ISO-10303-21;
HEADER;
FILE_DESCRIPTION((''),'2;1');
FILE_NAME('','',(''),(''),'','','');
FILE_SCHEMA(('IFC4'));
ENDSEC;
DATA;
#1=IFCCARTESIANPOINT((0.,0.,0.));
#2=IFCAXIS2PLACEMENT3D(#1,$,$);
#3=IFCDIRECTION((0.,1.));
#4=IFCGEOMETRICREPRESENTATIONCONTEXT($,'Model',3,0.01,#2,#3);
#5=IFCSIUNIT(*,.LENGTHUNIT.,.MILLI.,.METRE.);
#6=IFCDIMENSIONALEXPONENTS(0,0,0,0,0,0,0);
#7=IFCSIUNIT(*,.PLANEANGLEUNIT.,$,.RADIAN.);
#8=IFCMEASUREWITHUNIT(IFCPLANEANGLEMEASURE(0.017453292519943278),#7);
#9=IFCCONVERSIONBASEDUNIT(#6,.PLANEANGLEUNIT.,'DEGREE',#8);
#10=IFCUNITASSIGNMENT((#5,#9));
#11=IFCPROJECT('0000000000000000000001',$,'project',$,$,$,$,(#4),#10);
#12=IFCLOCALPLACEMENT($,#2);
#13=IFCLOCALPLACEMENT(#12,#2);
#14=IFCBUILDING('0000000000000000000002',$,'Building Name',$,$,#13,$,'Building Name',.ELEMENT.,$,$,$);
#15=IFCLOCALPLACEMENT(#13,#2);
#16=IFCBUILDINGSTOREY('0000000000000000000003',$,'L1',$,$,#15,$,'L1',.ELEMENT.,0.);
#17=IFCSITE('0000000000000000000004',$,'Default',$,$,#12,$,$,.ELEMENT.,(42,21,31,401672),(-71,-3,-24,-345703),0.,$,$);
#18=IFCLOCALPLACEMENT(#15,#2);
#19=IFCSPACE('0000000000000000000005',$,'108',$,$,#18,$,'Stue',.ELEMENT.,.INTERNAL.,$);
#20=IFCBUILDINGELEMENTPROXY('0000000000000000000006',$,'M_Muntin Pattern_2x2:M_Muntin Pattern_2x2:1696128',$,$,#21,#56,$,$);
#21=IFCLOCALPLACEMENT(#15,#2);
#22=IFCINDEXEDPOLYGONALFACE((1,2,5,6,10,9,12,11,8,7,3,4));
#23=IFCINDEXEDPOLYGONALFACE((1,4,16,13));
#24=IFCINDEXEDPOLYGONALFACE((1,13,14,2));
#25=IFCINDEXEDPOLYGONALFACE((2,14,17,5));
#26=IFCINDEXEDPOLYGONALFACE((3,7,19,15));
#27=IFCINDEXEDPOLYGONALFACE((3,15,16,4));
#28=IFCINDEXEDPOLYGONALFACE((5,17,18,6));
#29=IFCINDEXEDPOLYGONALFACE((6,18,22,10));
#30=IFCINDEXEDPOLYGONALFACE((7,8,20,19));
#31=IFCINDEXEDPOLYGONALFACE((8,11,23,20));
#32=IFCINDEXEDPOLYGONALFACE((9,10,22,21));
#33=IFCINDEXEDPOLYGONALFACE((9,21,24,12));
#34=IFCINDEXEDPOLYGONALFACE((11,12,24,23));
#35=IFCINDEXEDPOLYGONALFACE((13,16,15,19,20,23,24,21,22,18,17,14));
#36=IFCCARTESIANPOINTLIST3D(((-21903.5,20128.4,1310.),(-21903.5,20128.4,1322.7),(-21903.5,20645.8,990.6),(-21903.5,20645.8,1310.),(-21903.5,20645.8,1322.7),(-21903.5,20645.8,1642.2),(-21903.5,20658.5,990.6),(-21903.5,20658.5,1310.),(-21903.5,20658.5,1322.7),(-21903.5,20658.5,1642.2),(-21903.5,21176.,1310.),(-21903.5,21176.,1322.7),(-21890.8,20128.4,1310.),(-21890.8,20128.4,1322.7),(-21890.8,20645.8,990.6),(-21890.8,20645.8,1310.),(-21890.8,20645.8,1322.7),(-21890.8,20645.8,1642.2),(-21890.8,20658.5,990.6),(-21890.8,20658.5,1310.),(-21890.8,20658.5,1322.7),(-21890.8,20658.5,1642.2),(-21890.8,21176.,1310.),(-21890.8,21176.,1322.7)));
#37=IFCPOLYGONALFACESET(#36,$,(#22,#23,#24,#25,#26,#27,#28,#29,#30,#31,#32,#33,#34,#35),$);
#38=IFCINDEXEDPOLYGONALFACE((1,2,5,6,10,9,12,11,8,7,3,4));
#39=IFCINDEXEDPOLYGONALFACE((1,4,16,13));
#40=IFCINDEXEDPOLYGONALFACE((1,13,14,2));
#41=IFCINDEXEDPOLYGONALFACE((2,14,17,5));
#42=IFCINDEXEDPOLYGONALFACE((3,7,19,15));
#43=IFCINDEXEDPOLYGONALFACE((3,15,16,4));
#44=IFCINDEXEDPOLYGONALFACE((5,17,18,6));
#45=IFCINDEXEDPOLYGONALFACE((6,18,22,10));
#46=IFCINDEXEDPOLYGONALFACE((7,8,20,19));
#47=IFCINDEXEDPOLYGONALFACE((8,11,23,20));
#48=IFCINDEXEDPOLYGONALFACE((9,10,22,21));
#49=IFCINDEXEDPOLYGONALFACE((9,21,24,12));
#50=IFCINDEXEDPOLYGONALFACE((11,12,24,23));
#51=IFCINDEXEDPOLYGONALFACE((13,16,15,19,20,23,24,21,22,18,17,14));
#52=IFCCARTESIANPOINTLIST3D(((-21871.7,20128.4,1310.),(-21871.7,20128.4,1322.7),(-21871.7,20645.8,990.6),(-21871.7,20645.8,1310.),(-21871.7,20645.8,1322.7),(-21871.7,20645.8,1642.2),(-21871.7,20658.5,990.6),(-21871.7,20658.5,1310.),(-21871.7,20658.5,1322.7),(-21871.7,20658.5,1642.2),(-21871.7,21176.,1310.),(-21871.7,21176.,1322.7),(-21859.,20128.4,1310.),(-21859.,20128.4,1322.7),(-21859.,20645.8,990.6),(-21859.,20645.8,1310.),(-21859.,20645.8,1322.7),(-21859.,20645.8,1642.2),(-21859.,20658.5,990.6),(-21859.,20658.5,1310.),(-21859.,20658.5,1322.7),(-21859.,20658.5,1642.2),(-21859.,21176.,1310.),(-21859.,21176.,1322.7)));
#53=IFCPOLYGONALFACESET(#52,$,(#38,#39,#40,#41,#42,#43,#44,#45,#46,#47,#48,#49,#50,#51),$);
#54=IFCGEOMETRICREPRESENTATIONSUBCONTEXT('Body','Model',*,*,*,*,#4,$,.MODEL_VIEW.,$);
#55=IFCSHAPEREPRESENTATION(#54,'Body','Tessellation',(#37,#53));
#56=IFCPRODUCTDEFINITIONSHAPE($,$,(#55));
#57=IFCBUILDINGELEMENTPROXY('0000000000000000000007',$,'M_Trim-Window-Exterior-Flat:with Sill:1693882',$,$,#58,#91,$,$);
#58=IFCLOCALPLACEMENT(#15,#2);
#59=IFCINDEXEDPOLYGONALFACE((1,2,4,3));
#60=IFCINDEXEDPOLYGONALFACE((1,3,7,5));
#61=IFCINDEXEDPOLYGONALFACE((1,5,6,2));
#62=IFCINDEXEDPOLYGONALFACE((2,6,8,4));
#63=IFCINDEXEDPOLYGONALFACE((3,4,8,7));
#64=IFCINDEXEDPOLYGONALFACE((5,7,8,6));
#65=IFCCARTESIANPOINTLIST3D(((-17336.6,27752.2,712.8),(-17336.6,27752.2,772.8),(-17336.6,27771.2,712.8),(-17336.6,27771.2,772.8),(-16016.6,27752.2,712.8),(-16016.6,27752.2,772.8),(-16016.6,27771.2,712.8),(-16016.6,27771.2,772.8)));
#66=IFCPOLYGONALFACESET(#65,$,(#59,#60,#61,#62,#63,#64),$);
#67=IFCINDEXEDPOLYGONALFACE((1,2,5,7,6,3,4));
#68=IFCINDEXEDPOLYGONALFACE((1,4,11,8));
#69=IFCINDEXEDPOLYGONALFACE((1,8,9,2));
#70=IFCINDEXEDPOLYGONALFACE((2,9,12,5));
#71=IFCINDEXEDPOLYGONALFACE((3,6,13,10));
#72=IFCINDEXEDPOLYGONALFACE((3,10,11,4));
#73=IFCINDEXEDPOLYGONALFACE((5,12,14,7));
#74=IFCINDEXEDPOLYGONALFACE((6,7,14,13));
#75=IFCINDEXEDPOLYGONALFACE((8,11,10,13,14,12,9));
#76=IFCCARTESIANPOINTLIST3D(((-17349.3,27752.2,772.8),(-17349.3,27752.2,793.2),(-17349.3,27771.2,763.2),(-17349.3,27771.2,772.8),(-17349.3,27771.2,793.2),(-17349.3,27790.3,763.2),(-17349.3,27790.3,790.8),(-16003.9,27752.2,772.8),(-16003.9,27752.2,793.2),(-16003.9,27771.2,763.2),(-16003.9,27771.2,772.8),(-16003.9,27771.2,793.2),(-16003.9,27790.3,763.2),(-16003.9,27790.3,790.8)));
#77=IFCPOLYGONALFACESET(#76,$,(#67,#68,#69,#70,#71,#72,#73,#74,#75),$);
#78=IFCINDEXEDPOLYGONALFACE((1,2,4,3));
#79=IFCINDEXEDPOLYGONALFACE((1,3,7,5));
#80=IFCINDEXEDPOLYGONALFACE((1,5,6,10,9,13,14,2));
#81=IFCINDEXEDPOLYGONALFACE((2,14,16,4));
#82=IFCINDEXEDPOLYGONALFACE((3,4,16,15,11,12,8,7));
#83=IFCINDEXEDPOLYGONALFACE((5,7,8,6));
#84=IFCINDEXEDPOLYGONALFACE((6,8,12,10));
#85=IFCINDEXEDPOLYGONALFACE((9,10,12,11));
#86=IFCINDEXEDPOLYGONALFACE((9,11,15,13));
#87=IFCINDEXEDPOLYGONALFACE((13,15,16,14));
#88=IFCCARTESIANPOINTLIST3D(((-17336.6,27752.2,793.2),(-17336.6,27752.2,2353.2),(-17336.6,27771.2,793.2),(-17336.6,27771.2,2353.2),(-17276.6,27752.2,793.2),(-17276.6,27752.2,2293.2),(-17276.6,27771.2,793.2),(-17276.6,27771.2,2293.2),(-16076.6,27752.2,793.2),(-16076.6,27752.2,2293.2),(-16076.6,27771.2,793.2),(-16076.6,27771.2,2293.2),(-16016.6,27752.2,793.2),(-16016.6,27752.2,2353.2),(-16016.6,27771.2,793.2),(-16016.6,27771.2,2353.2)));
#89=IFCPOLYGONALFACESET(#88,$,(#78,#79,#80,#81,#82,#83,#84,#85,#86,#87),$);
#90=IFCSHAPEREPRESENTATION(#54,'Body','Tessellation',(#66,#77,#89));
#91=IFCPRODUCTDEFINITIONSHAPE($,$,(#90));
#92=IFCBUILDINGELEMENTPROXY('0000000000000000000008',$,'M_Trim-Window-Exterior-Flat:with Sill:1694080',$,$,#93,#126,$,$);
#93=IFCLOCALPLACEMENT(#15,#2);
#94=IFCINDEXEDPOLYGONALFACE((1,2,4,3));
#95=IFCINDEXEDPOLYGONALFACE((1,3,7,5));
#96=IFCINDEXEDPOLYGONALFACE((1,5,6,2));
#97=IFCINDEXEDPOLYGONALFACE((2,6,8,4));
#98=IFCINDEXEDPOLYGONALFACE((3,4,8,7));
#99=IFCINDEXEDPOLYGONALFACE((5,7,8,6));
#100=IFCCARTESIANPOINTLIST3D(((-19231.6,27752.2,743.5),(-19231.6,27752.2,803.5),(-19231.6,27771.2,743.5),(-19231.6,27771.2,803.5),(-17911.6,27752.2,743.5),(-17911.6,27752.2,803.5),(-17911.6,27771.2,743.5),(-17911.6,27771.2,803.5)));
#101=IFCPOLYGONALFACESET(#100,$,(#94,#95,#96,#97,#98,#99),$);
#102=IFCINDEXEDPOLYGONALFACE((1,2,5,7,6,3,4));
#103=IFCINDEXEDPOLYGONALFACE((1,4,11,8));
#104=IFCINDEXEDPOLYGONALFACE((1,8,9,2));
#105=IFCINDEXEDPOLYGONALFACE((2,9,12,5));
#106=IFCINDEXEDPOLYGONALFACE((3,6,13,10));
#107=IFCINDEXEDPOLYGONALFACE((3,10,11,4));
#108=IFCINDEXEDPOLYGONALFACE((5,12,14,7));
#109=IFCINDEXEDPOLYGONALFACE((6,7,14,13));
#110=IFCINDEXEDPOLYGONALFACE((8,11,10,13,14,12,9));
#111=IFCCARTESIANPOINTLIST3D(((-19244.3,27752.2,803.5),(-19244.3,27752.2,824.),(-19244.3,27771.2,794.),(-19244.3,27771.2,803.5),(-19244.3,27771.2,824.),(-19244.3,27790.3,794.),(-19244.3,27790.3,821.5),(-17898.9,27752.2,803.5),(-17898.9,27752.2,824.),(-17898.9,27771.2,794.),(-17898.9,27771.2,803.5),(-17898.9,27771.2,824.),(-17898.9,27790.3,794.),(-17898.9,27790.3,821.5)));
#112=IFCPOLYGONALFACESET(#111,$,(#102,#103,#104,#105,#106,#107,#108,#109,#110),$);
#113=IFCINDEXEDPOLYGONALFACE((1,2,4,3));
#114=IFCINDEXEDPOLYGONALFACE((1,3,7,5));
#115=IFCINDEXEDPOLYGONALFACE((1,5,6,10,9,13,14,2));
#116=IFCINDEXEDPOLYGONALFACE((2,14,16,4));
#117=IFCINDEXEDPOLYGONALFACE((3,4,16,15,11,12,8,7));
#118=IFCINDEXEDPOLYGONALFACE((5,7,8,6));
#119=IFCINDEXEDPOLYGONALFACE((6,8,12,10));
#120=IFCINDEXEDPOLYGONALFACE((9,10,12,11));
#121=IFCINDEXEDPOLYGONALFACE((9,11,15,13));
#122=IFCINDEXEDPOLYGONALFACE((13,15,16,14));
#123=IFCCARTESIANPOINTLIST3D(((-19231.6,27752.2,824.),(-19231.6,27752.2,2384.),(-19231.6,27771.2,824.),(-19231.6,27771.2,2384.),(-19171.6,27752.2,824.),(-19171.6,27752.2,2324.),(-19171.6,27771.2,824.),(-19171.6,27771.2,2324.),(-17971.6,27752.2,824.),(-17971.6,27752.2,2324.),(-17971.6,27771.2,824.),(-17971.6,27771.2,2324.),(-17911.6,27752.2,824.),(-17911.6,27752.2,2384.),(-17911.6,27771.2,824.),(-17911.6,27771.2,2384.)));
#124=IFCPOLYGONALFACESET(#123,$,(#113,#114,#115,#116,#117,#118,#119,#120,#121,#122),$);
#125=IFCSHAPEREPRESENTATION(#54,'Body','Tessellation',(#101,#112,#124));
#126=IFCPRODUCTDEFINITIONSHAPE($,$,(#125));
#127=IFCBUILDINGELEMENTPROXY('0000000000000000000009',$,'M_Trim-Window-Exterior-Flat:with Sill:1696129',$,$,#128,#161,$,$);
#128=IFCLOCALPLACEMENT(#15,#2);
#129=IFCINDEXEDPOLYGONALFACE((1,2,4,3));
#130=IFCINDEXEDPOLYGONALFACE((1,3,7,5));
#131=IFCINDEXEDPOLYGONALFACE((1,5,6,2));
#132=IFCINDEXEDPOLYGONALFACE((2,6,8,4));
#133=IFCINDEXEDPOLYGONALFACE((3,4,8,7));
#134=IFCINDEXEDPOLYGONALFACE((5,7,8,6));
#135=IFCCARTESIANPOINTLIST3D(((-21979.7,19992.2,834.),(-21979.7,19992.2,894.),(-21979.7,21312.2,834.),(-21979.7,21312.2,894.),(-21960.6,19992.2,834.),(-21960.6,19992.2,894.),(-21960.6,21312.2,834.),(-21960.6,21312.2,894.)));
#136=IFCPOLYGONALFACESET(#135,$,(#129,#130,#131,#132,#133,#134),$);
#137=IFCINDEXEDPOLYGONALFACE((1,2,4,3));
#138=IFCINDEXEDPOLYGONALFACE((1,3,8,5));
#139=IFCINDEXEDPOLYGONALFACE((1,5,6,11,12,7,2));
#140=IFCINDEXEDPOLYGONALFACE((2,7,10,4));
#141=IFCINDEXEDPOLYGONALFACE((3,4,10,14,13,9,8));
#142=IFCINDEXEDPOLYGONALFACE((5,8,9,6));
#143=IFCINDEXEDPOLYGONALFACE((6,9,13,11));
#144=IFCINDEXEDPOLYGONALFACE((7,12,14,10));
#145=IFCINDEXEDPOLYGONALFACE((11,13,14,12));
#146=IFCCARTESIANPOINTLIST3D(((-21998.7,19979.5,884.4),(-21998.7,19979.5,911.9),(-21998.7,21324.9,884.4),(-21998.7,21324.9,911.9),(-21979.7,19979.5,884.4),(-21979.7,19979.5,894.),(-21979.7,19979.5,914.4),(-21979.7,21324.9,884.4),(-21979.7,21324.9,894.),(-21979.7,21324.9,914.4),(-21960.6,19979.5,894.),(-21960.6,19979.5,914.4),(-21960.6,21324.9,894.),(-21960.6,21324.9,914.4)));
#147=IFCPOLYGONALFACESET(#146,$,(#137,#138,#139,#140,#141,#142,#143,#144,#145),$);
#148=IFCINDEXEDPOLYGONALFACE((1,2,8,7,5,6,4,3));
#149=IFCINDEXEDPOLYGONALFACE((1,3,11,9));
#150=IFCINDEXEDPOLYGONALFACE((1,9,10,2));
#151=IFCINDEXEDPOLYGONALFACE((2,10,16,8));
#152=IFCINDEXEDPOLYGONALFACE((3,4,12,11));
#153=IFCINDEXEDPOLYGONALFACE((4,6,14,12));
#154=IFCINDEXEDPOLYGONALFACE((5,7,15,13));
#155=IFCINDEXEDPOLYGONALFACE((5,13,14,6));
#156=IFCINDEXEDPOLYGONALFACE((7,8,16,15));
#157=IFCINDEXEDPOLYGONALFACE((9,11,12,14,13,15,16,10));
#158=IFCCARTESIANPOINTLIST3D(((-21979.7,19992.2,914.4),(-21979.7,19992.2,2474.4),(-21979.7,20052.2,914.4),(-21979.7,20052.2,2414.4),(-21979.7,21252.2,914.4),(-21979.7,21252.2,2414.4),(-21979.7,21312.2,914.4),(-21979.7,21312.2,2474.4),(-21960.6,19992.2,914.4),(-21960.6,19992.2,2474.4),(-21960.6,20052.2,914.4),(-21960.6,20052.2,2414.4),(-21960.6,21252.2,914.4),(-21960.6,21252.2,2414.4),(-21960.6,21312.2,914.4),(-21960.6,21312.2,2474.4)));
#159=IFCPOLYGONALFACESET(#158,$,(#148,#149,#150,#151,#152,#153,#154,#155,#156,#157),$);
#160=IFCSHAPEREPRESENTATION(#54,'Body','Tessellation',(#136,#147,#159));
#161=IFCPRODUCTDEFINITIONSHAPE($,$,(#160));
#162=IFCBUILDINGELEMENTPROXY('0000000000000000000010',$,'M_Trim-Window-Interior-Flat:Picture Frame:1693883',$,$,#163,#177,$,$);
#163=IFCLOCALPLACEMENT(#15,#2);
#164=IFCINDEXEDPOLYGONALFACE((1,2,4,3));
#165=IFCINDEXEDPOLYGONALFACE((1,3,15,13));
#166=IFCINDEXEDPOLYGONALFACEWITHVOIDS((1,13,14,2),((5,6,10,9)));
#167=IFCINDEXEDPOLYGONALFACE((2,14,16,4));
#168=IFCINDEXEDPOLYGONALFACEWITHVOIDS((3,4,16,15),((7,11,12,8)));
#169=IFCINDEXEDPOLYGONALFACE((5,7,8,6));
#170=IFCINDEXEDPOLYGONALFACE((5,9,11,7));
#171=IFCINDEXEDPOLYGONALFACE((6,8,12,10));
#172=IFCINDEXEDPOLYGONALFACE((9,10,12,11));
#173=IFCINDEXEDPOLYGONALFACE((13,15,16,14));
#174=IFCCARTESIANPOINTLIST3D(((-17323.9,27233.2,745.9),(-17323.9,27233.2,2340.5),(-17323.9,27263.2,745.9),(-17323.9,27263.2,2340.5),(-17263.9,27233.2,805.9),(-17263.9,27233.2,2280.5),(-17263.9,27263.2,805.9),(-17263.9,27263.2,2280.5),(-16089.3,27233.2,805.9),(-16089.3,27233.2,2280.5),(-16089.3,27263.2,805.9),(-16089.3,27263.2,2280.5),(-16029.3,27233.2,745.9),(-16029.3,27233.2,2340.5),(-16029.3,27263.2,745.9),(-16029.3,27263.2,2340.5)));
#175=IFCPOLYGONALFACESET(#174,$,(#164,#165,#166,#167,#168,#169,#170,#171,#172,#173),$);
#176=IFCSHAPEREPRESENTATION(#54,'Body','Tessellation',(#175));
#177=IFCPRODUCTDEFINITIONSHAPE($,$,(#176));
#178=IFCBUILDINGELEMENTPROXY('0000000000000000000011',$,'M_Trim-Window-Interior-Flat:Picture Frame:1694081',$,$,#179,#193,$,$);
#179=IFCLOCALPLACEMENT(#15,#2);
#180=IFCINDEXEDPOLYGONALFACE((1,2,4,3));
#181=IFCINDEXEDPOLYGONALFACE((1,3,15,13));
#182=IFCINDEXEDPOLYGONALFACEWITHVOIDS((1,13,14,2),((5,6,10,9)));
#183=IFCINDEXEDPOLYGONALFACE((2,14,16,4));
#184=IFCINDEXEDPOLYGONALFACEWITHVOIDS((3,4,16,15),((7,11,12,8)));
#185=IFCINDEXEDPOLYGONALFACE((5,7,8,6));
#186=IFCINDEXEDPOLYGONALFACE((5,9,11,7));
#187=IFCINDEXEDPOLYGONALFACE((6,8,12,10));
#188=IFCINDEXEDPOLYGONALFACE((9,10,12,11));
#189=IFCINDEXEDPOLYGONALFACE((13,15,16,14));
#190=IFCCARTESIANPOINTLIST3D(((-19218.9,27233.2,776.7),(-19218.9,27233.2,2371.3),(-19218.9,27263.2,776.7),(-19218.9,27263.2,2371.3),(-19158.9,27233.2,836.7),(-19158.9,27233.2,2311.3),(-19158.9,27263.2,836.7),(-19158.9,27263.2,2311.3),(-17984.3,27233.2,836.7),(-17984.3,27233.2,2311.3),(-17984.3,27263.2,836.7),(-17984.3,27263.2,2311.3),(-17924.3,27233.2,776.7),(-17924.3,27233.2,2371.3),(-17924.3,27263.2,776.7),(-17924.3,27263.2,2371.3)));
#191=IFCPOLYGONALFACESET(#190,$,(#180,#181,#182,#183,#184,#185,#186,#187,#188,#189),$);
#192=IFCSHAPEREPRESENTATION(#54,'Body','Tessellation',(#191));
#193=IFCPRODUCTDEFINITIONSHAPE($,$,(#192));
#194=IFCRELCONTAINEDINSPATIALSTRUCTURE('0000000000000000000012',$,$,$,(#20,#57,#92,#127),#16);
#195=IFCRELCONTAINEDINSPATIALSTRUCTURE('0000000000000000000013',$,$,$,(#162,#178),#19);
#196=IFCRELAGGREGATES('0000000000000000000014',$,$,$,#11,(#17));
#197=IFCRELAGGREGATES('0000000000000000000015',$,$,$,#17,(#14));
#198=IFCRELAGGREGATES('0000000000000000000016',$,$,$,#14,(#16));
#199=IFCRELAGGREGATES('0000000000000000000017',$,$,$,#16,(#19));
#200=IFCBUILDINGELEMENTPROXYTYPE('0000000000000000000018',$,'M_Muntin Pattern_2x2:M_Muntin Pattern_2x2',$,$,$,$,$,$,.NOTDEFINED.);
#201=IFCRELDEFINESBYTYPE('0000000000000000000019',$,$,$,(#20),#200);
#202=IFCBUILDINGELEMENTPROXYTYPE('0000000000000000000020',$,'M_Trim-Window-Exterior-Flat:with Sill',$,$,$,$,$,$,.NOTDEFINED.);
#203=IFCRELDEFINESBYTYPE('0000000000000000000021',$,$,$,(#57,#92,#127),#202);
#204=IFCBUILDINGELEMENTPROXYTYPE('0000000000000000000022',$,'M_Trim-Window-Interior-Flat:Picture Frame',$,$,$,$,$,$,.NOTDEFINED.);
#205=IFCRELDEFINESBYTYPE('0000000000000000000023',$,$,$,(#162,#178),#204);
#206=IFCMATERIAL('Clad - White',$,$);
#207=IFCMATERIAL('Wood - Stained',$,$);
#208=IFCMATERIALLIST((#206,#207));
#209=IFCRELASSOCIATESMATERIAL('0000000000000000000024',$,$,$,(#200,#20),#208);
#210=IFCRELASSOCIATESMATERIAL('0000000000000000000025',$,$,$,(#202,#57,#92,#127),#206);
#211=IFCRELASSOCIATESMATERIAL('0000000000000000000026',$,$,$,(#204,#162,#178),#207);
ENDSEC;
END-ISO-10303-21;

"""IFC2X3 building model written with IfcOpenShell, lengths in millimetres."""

from ifc_helpers import new_model, entity, si_unit, converted_unit, direction, frame, frame_2d, origin, place, context, subcontext, project, spatial, polyline, rectangle, outline, extrude, source, transform, mapped, material, material_list, type_object, type_shapes, element, save


model = new_model("IFC2X3")

# Units and contexts
model_context = context("Model", 3, precision=0.01, world=origin(), true_north=direction((0.0, 1.0)))
body_context = subcontext(model_context, "Body", "Model", "MODEL_VIEW")
ifc_project = project(units=[si_unit("LENGTHUNIT", "METRE", prefix="MILLI"), converted_unit("PLANEANGLEUNIT", "DEGREE", entity("IfcPlaneAngleMeasure", 0.017453292519943278), si_unit("PLANEANGLEUNIT", "RADIAN"), dimensions=[0, 0, 0, 0, 0, 0, 0])], contexts=[model_context])

# Site, building, storey
site_placement = place(None, origin())
site = spatial("IfcSite", under=ifc_project, at=site_placement, Name="Default", CompositionType="ELEMENT", RefLatitude=(42, 21, 31, 401672), RefLongitude=(-71, -3, -24, -345703), RefElevation=0.0)
building_placement = place(site_placement, origin())
building = spatial("IfcBuilding", under=site, at=building_placement, Name="Building Name", LongName="Building Name", CompositionType="ELEMENT")
storey_placement = place(building_placement, origin())
storey = spatial("IfcBuildingStorey", under=building, at=storey_placement, Name="L1", LongName="L1", CompositionType="ELEMENT", Elevation=0.0)

# Shared definitions
ifc_material_1 = material(Name="Wood - Stained")

# Building element proxies
ifc_material_2 = material(Name="Clad - White")
ifc_material_list_1 = material_list([ifc_material_2, ifc_material_1])
building_element_proxy_type_1 = type_object("IfcBuildingElementProxyType", Name="M_Muntin Pattern_2x2:M_Muntin Pattern_2x2", PredefinedType="NOTDEFINED", material=ifc_material_list_1)
shared_shape_1 = source(origin(), body_context, "Body", "SweptSolid", [
    extrude(outline(polyline([(6.4, -6.4), (325.8, -6.4), (325.8, 6.3), (6.4, 6.3), (6.4, 523.8), (-6.3, 523.8), (-6.3, 6.3), (-325.8, 6.3), (-325.8, -6.4), (-6.3, -6.4), (-6.3, -523.8), (6.4, -523.8), (6.4, -6.4)])), frame((0.0, 9.5, 325.8), z_axis=(0.0, 1.0, 0.0), x_axis=(0.0, 0.0, 1.0)), (0.0, 0.0, 1.0), 12.7),
    extrude(outline(polyline([(6.4, -6.4), (325.8, -6.4), (325.8, 6.3), (6.4, 6.3), (6.4, 523.8), (-6.3, 523.8), (-6.3, 6.3), (-325.8, 6.3), (-325.8, -6.4), (-6.3, -6.4), (-6.3, -523.8), (6.4, -523.8), (6.4, -6.4)])), frame((0.0, -22.2, 325.8), z_axis=(0.0, 1.0, 0.0), x_axis=(0.0, 0.0, 1.0)), (0.0, 0.0, 1.0), 12.7),
])
type_shapes(building_element_proxy_type_1, [shared_shape_1])
proxy_1_placement = place(storey_placement, frame((-21881.3, 20652.2, 990.6), z_axis=(0.0, 0.0, 1.0), x_axis=(0.0, 1.0, 0.0)))
element("IfcBuildingElementProxy", 1, at=proxy_1_placement, inside=storey, type_object=building_element_proxy_type_1, material=ifc_material_list_1, Name="M_Muntin Pattern_2x2:M_Muntin Pattern_2x2:1696128", context=body_context, shape_type="MappedRepresentation", body=[
    mapped(shared_shape_1, transform((0.0, 0.0, 0.0), scale=1.0)),
])
building_element_proxy_type_2 = type_object("IfcBuildingElementProxyType", Name="M_Trim-Window-Exterior-Flat:with Sill", PredefinedType="NOTDEFINED", material=ifc_material_2)
shared_shape_2 = source(origin(), body_context, "Body", "SweptSolid", [
    extrude(rectangle(XDim=1320.0, YDim=60.0, at=frame_2d((0.0, 0.0), x_axis=(1.0, 0.0))), frame((0.0, -1550.4, 0.0), z_axis=(0.0, 0.0, 1.0), x_axis=(-1.0, 0.0, 0.0)), (0.0, 0.0, 1.0), 19.0),
    extrude(outline(polyline([(-19.0, -15.2), (0.0, -15.2), (0.0, -5.7), (19.0, -5.7), (19.0, 14.8), (0.0, 14.8), (-19.0, 12.3), (-19.0, -15.2)])), frame((-672.7, -1514.8, 19.0), z_axis=(1.0, 0.0, 0.0), x_axis=(0.0, 0.0, -1.0)), (0.0, 0.0, 1.0), 1345.4),
    extrude(outline(polyline([(-795.0, -660.0), (765.0, -660.0), (765.0, -600.0), (-735.0, -600.0), (-735.0, 600.0), (765.0, 600.0), (765.0, 660.0), (-795.0, 660.0), (-795.0, -660.0)])), frame((0.0, -735.0, 0.0), z_axis=(0.0, 0.0, 1.0), x_axis=(0.0, -1.0, 0.0)), (0.0, 0.0, 1.0), 19.0),
])
type_shapes(building_element_proxy_type_2, [shared_shape_2])
for number, where, z_axis, x_axis, name in (
    (2, (-16676.6, 27752.2, 2293.2), (0.0, 1.0, 0.0), (-1.0, 0.0, 0.0), "M_Trim-Window-Exterior-Flat:with Sill:1693882"),
    (3, (-18571.6, 27752.2, 2324.0), (0.0, 1.0, 0.0), (-1.0, 0.0, 0.0), "M_Trim-Window-Exterior-Flat:with Sill:1694080"),
    (4, (-21960.6, 20652.2, 2414.4), (-1.0, 0.0, 0.0), (0.0, -1.0, 0.0), "M_Trim-Window-Exterior-Flat:with Sill:1696129"),
):
    element("IfcBuildingElementProxy", number, at=place(storey_placement, frame(where, z_axis=z_axis, x_axis=x_axis)), inside=storey, type_object=building_element_proxy_type_2, material=ifc_material_2, Name=name, context=body_context, shape_type="MappedRepresentation", body=[
        mapped(shared_shape_2, transform((0.0, 0.0, 0.0), scale=1.0)),
    ])

# Shared definitions
space_1_placement = place(storey_placement, origin())
space_1 = spatial("IfcSpace", under=storey, at=space_1_placement, Name="108", LongName="Stue", CompositionType="ELEMENT", InteriorOrExteriorSpace="INTERNAL")

# Building element proxies
building_element_proxy_type_3 = type_object("IfcBuildingElementProxyType", Name="M_Trim-Window-Interior-Flat:Picture Frame", PredefinedType="NOTDEFINED", material=ifc_material_1)
shared_shape_3 = source(origin(), body_context, "Body", "SweptSolid", [
    extrude(outline(polyline([(-647.3, -797.3), (647.3, -797.3), (647.3, 797.3), (-647.3, 797.3), (-647.3, -797.3)]), holes=[polyline([(-587.3, -737.3), (-587.3, 737.3), (587.3, 737.3), (587.3, -737.3), (-587.3, -737.3)])]), frame((0.0, -750.0, 0.0), z_axis=(0.0, 0.0, 1.0), x_axis=(-1.0, 0.0, 0.0)), (0.0, 0.0, 1.0), 30.0),
])
type_shapes(building_element_proxy_type_3, [shared_shape_3])
for number, where, z_axis, x_axis, name in (
    (5, (-16676.6, 27263.2, 2293.2), (0.0, -1.0, 0.0), (1.0, 0.0, 0.0), "M_Trim-Window-Interior-Flat:Picture Frame:1693883"),
    (6, (-18571.6, 27263.2, 2324.0), (0.0, -1.0, 0.0), (1.0, 0.0, 0.0), "M_Trim-Window-Interior-Flat:Picture Frame:1694081"),
):
    element("IfcBuildingElementProxy", number, at=place(space_1_placement, frame(where, z_axis=z_axis, x_axis=x_axis)), inside=space_1, type_object=building_element_proxy_type_3, material=ifc_material_1, Name=name, context=body_context, shape_type="MappedRepresentation", body=[
        mapped(shared_shape_3, transform((0.0, 0.0, 0.0), scale=1.0)),
    ])

save(model, "model.ifc")
